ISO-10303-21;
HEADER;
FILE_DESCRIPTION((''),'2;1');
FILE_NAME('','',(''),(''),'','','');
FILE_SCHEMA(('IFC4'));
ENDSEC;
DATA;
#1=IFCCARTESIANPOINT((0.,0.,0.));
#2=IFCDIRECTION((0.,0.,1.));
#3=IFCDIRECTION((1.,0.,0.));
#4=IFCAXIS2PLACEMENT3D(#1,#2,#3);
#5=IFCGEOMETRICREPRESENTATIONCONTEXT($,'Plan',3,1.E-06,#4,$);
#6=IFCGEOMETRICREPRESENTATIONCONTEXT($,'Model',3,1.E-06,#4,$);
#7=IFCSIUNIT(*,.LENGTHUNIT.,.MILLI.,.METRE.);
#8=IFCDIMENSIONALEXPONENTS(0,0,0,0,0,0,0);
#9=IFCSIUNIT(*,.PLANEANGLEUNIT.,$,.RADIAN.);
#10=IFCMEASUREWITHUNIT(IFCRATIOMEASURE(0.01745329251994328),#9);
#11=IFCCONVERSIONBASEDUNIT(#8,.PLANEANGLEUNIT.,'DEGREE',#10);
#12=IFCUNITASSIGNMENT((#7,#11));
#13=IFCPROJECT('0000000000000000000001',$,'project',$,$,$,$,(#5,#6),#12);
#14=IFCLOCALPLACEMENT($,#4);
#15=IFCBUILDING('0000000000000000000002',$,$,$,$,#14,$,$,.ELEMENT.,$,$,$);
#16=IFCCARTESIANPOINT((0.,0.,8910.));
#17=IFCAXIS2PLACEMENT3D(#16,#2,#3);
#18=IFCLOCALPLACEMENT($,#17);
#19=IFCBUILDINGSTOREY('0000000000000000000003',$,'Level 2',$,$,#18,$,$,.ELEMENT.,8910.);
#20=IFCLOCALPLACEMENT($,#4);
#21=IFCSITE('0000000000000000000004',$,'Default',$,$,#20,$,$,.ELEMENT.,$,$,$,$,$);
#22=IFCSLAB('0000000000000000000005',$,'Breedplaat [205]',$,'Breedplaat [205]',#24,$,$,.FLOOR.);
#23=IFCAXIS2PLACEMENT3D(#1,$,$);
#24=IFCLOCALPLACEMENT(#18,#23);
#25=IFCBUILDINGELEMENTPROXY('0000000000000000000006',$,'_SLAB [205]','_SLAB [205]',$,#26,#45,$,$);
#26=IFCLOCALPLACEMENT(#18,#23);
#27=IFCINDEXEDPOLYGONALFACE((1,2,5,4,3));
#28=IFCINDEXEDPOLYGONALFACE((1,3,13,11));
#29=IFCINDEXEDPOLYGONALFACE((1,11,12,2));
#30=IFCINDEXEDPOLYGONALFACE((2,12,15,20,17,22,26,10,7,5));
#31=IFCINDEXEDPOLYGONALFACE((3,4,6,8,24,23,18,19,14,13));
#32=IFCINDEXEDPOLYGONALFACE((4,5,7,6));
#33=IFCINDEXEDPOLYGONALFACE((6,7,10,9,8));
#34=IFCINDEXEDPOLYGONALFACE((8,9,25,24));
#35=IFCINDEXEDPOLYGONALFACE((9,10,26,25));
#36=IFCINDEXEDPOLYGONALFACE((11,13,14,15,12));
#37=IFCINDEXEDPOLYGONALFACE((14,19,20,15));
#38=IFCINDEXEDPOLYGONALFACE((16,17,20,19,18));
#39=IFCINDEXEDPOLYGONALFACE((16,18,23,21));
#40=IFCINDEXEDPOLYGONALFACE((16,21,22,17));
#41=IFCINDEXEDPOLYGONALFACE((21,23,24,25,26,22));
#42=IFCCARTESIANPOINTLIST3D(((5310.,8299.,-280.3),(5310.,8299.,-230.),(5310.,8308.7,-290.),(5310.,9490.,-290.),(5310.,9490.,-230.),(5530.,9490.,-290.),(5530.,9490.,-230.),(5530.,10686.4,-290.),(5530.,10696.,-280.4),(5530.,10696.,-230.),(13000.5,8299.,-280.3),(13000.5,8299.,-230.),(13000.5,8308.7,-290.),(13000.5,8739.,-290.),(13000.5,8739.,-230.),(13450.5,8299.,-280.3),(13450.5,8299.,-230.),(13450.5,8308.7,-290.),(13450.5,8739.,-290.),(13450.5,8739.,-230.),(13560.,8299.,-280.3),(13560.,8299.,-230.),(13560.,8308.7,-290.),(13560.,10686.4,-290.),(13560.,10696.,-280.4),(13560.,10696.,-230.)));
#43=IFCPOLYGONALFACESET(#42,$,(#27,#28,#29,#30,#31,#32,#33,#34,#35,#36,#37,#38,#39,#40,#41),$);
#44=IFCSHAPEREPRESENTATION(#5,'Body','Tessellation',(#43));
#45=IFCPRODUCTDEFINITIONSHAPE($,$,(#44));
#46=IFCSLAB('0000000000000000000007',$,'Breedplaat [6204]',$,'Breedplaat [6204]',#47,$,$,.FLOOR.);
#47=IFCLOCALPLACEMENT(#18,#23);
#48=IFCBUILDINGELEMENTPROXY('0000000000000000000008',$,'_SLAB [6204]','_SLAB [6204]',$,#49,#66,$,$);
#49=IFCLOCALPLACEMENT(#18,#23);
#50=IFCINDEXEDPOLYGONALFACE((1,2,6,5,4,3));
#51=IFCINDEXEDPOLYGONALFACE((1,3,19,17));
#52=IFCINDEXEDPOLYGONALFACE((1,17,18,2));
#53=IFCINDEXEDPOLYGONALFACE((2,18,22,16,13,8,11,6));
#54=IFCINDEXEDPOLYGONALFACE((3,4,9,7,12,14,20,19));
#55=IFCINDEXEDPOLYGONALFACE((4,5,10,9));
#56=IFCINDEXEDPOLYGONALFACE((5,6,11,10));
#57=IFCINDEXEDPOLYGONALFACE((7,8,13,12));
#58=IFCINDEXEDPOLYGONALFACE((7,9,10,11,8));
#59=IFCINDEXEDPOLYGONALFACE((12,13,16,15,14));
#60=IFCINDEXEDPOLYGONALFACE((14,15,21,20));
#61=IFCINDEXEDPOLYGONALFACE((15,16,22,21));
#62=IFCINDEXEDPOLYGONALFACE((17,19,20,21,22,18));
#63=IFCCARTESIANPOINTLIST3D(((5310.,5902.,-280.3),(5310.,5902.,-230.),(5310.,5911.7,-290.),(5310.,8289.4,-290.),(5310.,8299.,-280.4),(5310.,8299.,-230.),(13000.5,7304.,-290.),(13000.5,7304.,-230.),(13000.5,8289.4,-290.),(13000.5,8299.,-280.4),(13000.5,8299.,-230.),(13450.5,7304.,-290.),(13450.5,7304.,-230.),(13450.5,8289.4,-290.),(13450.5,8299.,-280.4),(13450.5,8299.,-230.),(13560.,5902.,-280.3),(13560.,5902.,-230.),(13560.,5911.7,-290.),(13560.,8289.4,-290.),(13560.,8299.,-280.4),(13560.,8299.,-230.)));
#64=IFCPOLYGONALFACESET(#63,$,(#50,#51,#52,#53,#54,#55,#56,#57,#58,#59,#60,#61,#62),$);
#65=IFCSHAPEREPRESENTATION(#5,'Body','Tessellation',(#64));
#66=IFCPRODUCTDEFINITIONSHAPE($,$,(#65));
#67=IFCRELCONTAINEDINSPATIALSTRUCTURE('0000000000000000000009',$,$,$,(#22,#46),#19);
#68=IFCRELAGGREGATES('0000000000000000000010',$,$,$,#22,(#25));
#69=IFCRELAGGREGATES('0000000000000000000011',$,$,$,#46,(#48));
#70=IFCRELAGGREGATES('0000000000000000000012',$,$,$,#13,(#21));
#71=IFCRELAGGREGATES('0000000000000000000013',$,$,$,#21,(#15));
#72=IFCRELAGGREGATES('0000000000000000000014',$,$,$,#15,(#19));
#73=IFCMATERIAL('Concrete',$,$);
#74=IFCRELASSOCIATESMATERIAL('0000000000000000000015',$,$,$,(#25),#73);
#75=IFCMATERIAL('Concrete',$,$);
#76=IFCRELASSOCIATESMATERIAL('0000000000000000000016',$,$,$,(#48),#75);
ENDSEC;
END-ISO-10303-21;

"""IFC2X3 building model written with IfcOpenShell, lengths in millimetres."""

from ifc_helpers import new_model, entity, si_unit, converted_unit, frame, origin_with_axes, origin_2d_with_axis, place, context, project, spatial, polyline, rectangle, outline, extrude, material, element, aggregate, save


model = new_model("IFC2X3")

# Units and contexts
plan_context = context("Plan", 3, precision=1e-06, world=origin_with_axes())
model_context = context("Model", 3, precision=1e-06, world=origin_with_axes())
ifc_project = project(units=[si_unit("LENGTHUNIT", "METRE", prefix="MILLI"), converted_unit("PLANEANGLEUNIT", "DEGREE", entity("IfcRatioMeasure", 0.01745329251994328), si_unit("PLANEANGLEUNIT", "RADIAN"), dimensions=[0, 0, 0, 0, 0, 0, 0])], contexts=[plan_context, model_context])

# Site, building, storey
site_placement = place(None, origin_with_axes())
site = spatial("IfcSite", under=ifc_project, at=site_placement, Name="Default", CompositionType="ELEMENT")
building_placement = place(None, origin_with_axes())
building = spatial("IfcBuilding", under=site, at=building_placement, CompositionType="ELEMENT")
storey_placement = place(None, frame((0.0, 0.0, 8910.0), z_axis=(0.0, 0.0, 1.0), x_axis=(1.0, 0.0, 0.0)))
storey = spatial("IfcBuildingStorey", under=building, at=storey_placement, Name="Level 2", CompositionType="ELEMENT", Elevation=8910.0)

# Slab, building element proxy, openings
slab_1_placement = place(None, frame((5310.0, 8299.0, 8620.0), z_axis=(0.0, 0.0, 1.0), x_axis=(1.0, 0.0, 0.0)))
slab_1 = element("IfcSlab", 1, at=slab_1_placement, inside=storey, Name="Breedplaat [205]", ObjectType="Breedplaat [205]", PredefinedType="FLOOR")
ifc_material_1 = material(Name="Concrete")
proxy_1_placement = place(slab_1_placement, origin_with_axes())
proxy_1 = element("IfcBuildingElementProxy", 2, at=proxy_1_placement, material=ifc_material_1, Name="_SLAB [205]", Description="_SLAB [205]", context=plan_context, shape_type="SweptSolid", body=[
    extrude(outline(polyline([(220.0, 2397.0), (220.0, 1191.0), (0.0, 1191.0), (0.0, 0.0), (8250.0, 0.0), (8250.0, 2397.0), (220.0, 2397.0)])), origin_with_axes(), (0.0, 0.0, 1.0), 60.0),
])
opening_1_placement = place(slab_1_placement, frame((7690.5, 0.0, 0.0), z_axis=(0.0, 0.0, 1.0), x_axis=(1.0, 0.0, 0.0)))
element("IfcOpeningElement", 3, at=opening_1_placement, cuts=proxy_1, ObjectType="Opening", context=plan_context, shape_type="SolidModel", body=[
    extrude(rectangle(XDim=450.0, YDim=440.0, at=origin_2d_with_axis()), frame((225.0, 220.0, 0.0), z_axis=(0.0, 0.0, 1.0), x_axis=(1.0, 0.0, 0.0)), (0.0, 0.0, 1.0), 60.0),
])
opening_2_placement = place(None, frame((5310.0, 8299.0, 8620.0), z_axis=(0.0, 0.0, 1.0), x_axis=(1.0, 0.0, 0.0)))
element("IfcOpeningElement", 4, at=opening_2_placement, cuts=proxy_1, ObjectType="Opening", context=plan_context, shape_type="SweptSolid", body=[
    extrude(outline(polyline([(-0.1, -0.1), (-0.1, 10.0), (10.0, -0.1), (-0.1, -0.1)])), frame((-1.2, -0.1, -0.1), z_axis=(1.0, 0.0, 0.0), x_axis=(0.0, 1.0, 0.0)), (0.0, 0.0, 1.0), 8252.2),
])
opening_3_placement = place(None, frame((5310.0, 8299.0, 8620.0), z_axis=(0.0, 0.0, 1.0), x_axis=(1.0, 0.0, 0.0)))
element("IfcOpeningElement", 5, at=opening_3_placement, cuts=proxy_1, ObjectType="Opening", context=plan_context, shape_type="SweptSolid", body=[
    extrude(outline(polyline([(-0.1, -0.1), (-0.1, 10.0), (10.0, -0.1), (-0.1, -0.1)])), frame((8251.2, 2397.2, -0.1), z_axis=(-1.0, 0.0, 0.0), x_axis=(0.0, -1.0, 0.0)), (0.0, 0.0, 1.0), 8032.2),
])
aggregate(slab_1, [proxy_1])

# Slab, building element proxy, openings
slab_2_placement = place(None, frame((5310.0, 5902.0, 8620.0), z_axis=(0.0, 0.0, 1.0), x_axis=(1.0, 0.0, 0.0)))
slab_2 = element("IfcSlab", 6, at=slab_2_placement, inside=storey, Name="Breedplaat [6204]", ObjectType="Breedplaat [6204]", PredefinedType="FLOOR")
ifc_material_2 = material(Name="Concrete")
proxy_2_placement = place(slab_2_placement, origin_with_axes())
proxy_2 = element("IfcBuildingElementProxy", 7, at=proxy_2_placement, material=ifc_material_2, Name="_SLAB [6204]", Description="_SLAB [6204]", context=plan_context, shape_type="SweptSolid", body=[
    extrude(outline(polyline([(0.0, 2397.0), (0.0, 0.0), (8250.0, 0.0), (8250.0, 2397.0), (0.0, 2397.0)])), origin_with_axes(), (0.0, 0.0, 1.0), 60.0),
])
opening_4_placement = place(slab_2_placement, frame((7690.5, 1402.0, 0.0), z_axis=(0.0, 0.0, 1.0), x_axis=(1.0, 0.0, 0.0)))
element("IfcOpeningElement", 8, at=opening_4_placement, cuts=proxy_2, ObjectType="Opening", context=plan_context, shape_type="SolidModel", body=[
    extrude(rectangle(XDim=450.0, YDim=995.0, at=origin_2d_with_axis()), frame((225.0, 497.5, 0.0), z_axis=(0.0, 0.0, 1.0), x_axis=(1.0, 0.0, 0.0)), (0.0, 0.0, 1.0), 60.0),
])
opening_5_placement = place(None, frame((5310.0, 5902.0, 8620.0), z_axis=(0.0, 0.0, 1.0), x_axis=(1.0, 0.0, 0.0)))
element("IfcOpeningElement", 9, at=opening_5_placement, cuts=proxy_2, ObjectType="Opening", context=plan_context, shape_type="SweptSolid", body=[
    extrude(outline(polyline([(-0.1, -0.1), (-0.1, 10.0), (10.0, -0.1), (-0.1, -0.1)])), frame((-1.2, -0.1, -0.1), z_axis=(1.0, 0.0, 0.0), x_axis=(0.0, 1.0, 0.0)), (0.0, 0.0, 1.0), 8252.2),
])
opening_6_placement = place(None, frame((5310.0, 5902.0, 8620.0), z_axis=(0.0, 0.0, 1.0), x_axis=(1.0, 0.0, 0.0)))
element("IfcOpeningElement", 10, at=opening_6_placement, cuts=proxy_2, ObjectType="Opening", context=plan_context, shape_type="SweptSolid", body=[
    extrude(outline(polyline([(-0.1, -0.1), (-0.1, 10.0), (10.0, -0.1), (-0.1, -0.1)])), frame((8251.2, 2397.2, -0.1), z_axis=(-1.0, 0.0, 0.0), x_axis=(0.0, -1.0, 0.0)), (0.0, 0.0, 1.0), 8252.2),
])
aggregate(slab_2, [proxy_2])

save(model, "model.ifc")
